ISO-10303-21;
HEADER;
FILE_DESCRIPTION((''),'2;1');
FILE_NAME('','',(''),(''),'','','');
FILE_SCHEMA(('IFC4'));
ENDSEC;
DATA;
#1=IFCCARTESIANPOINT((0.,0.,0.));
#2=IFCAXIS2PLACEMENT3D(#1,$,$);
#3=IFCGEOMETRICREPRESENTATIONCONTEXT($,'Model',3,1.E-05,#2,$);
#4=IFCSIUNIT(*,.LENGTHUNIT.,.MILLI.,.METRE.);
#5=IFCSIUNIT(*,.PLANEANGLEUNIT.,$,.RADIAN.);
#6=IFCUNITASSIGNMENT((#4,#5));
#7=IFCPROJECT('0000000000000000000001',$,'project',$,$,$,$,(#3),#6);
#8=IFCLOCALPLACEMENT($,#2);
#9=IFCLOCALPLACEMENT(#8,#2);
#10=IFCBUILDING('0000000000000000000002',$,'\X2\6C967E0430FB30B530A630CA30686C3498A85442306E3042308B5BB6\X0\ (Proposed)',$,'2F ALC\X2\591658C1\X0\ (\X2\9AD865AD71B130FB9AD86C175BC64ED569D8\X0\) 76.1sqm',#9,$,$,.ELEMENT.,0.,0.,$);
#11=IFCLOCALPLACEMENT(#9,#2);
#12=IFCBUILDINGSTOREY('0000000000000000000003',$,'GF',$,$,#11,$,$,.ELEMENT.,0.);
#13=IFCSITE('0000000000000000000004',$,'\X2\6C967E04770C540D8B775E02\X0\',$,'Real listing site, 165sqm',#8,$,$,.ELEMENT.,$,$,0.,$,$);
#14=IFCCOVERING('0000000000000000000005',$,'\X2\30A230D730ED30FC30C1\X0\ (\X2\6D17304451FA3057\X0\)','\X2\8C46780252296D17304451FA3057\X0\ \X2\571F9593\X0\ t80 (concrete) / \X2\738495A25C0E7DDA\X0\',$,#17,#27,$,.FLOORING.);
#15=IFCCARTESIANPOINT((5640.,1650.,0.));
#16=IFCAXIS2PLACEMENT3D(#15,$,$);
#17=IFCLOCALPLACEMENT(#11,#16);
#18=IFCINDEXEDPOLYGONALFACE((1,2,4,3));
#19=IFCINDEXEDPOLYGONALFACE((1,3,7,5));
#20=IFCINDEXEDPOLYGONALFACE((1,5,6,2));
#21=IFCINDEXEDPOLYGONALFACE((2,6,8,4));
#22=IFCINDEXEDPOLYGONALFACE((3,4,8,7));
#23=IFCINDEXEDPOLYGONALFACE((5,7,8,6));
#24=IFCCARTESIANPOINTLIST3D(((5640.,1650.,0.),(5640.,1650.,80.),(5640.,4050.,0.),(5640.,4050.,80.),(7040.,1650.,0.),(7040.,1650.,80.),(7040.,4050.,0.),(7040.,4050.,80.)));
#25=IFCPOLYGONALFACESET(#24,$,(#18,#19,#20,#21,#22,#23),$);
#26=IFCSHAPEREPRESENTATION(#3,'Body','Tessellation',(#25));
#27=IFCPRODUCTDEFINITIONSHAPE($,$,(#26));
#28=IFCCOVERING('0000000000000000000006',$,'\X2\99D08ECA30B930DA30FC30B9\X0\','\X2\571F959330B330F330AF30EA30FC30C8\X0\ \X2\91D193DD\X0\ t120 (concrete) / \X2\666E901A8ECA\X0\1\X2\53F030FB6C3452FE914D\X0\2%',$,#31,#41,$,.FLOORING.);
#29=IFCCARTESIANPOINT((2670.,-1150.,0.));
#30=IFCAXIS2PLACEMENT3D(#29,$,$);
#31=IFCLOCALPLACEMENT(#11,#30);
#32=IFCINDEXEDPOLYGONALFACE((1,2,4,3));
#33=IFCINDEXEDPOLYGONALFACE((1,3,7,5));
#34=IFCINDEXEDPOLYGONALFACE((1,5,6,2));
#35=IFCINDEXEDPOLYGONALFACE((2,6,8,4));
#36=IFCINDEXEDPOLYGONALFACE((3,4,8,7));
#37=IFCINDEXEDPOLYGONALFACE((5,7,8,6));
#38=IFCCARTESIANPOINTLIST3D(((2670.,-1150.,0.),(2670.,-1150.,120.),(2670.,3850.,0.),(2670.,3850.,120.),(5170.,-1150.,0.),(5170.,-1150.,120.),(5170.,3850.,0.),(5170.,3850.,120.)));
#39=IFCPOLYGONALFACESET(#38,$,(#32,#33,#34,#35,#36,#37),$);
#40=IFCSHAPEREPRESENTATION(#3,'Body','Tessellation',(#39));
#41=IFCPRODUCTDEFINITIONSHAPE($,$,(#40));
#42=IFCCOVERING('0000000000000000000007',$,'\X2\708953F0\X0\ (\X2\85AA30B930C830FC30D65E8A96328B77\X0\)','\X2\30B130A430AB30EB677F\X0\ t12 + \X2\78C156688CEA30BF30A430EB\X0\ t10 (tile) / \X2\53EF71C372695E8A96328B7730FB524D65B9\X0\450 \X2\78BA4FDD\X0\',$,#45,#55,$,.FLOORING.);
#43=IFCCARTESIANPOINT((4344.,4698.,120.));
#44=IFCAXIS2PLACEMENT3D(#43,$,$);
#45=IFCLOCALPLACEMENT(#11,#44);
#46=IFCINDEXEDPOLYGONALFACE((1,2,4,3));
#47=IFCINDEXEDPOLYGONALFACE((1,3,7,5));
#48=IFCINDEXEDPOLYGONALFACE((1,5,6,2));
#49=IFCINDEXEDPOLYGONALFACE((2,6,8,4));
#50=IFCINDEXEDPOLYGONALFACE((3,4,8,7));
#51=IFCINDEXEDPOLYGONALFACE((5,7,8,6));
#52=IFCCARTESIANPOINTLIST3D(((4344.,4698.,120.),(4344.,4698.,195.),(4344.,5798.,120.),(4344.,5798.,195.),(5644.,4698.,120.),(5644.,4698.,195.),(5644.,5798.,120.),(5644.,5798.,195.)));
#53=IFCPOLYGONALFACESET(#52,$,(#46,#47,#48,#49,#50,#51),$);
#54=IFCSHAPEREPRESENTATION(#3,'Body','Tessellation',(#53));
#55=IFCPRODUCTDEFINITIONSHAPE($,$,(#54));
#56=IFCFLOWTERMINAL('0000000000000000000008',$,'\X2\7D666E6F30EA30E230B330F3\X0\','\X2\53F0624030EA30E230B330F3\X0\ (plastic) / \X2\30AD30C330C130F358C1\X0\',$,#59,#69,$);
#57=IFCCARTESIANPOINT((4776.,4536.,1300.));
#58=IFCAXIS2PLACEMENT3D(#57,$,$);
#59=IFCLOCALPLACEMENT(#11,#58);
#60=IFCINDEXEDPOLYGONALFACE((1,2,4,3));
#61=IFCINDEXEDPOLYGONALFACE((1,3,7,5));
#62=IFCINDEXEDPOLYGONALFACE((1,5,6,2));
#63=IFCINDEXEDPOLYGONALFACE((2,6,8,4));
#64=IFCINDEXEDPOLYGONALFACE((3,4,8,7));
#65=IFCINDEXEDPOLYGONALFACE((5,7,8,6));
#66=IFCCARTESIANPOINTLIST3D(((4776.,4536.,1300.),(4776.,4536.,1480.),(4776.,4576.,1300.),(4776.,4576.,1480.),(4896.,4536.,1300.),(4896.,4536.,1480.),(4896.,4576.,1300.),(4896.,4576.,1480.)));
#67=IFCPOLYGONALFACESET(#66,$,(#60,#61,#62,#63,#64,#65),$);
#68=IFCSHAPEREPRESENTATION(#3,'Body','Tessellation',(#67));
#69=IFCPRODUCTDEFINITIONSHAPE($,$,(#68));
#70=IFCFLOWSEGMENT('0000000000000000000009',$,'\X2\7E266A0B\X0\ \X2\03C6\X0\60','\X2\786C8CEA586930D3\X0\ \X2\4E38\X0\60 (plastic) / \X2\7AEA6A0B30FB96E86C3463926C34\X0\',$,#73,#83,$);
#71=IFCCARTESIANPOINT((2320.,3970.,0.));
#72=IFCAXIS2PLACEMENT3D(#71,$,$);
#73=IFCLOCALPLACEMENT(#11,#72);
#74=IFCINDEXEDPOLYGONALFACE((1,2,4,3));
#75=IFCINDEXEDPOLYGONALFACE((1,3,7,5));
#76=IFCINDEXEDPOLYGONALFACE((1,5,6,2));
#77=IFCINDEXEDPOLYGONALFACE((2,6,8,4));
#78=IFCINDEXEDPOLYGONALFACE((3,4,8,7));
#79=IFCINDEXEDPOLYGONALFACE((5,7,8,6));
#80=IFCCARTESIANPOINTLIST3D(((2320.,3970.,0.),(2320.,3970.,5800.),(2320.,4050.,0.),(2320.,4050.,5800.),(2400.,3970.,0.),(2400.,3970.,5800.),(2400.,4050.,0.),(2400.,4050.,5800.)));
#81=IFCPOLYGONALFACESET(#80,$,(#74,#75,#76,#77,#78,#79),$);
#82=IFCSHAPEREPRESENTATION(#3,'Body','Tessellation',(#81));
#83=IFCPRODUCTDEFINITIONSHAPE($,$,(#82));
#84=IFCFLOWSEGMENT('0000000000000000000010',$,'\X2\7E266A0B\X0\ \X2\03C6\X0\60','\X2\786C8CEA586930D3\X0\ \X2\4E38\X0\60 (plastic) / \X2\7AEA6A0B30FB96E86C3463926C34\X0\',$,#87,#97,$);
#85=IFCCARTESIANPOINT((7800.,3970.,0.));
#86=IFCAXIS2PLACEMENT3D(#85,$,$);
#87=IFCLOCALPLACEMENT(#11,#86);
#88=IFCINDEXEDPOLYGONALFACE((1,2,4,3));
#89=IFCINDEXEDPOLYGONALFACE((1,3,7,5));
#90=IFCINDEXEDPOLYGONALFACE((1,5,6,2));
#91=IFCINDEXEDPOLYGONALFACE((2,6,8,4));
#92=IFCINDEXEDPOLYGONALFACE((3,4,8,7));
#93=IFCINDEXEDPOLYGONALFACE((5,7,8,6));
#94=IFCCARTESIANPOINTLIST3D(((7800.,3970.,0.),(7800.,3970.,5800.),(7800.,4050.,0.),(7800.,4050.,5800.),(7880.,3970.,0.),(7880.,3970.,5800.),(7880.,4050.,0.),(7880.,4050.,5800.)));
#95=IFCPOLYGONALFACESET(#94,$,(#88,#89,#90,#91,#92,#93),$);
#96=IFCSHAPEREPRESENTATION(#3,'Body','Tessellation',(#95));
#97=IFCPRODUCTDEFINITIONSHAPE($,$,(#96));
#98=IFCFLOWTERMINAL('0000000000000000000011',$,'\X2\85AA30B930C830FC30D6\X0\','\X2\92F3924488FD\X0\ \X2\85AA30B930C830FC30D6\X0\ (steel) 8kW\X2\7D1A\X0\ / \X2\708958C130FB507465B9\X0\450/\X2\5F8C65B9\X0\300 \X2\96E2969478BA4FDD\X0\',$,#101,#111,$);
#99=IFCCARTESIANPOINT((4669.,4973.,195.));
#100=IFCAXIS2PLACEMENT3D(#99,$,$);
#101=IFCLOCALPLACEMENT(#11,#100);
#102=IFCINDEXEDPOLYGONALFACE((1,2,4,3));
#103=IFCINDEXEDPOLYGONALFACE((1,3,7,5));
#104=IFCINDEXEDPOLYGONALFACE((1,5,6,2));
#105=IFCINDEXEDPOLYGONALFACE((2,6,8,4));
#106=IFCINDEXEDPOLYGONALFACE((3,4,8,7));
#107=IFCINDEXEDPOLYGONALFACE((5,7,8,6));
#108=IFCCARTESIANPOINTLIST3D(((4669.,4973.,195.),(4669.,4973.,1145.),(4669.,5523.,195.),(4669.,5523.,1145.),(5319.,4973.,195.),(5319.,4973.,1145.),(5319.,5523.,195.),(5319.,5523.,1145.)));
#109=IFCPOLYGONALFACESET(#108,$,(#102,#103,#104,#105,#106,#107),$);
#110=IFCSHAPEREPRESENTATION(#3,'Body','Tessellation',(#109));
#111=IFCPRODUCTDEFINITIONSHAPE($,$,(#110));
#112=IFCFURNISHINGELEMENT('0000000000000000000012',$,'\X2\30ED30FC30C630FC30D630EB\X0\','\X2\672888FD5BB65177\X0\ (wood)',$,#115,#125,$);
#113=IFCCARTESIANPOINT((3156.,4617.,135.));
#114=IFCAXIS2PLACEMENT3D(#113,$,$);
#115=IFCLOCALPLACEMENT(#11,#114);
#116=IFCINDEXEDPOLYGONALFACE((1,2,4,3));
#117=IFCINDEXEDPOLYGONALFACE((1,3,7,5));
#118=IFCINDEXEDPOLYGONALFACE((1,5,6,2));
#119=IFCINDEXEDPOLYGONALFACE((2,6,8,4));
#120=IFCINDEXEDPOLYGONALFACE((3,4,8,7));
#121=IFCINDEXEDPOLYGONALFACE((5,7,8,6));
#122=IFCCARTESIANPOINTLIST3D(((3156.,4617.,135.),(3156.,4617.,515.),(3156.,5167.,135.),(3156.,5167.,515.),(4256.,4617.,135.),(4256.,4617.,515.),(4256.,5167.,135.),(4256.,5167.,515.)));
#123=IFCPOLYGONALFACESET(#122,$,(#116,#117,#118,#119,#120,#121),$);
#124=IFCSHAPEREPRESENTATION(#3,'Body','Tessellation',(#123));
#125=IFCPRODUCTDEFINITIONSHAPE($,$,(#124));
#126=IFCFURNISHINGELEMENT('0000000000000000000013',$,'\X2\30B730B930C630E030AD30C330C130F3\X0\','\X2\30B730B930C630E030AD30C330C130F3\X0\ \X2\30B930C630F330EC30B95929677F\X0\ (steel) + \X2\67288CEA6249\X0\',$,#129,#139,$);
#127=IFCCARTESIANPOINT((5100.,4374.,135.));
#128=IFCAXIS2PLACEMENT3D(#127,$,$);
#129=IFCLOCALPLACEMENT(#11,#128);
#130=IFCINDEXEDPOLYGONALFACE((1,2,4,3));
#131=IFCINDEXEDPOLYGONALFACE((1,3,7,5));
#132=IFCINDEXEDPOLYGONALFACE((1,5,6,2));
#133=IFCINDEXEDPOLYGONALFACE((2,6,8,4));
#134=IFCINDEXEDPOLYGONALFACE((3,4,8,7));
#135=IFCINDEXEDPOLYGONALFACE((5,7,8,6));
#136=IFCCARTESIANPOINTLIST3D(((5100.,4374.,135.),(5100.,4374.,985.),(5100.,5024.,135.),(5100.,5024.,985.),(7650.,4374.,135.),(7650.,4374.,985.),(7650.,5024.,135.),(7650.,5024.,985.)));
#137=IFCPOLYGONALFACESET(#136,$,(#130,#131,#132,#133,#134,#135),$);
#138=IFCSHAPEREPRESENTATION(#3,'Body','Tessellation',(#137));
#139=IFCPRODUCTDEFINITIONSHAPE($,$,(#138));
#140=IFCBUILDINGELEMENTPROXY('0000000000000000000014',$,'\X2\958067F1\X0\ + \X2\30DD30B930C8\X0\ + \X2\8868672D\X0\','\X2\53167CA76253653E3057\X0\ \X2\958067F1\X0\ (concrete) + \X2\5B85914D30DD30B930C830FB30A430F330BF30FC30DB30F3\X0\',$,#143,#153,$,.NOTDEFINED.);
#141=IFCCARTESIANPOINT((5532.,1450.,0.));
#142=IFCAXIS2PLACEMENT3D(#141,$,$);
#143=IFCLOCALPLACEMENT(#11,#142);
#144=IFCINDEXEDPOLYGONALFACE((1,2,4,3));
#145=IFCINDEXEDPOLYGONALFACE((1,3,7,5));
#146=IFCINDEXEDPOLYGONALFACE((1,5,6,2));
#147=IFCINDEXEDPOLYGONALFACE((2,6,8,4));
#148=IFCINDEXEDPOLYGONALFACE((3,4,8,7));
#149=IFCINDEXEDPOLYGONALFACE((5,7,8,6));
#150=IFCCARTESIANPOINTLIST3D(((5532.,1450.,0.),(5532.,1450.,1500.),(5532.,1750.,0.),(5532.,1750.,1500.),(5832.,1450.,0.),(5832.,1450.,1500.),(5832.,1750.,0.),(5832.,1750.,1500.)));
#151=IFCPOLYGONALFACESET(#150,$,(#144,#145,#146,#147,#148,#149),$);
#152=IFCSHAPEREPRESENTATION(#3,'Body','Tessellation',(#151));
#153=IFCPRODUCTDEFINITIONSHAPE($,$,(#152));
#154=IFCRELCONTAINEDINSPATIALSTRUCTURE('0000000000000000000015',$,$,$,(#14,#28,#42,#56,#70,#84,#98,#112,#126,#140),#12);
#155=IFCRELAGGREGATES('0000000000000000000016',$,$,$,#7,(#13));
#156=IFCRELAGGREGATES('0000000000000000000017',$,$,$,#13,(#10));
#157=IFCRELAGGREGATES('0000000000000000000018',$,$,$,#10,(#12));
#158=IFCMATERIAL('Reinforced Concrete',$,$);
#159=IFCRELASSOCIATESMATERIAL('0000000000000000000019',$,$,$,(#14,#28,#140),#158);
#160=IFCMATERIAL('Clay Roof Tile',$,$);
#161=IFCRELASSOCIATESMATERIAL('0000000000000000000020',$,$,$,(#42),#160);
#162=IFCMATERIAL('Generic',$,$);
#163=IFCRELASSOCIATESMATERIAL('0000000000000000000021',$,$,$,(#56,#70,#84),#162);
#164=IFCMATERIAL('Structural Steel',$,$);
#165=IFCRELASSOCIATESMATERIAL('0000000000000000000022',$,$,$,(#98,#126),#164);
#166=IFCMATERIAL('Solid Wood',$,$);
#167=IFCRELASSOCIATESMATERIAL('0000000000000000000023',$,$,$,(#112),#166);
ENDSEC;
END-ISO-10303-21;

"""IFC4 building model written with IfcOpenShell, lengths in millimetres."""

from ifc_helpers import new_model, si_unit, frame, frame_2d, origin, place, context, project, spatial, rectangle, extrude, material, element, save


model = new_model("IFC4")

# Units and contexts
model_context = context("Model", 3, precision=1e-05, world=origin())
ifc_project = project(units=[si_unit("LENGTHUNIT", "METRE", prefix="MILLI"), si_unit("PLANEANGLEUNIT", "RADIAN")], contexts=[model_context])

# Site, building, storey
site_placement = place(None, origin())
site = spatial("IfcSite", under=ifc_project, at=site_placement, Name="沖縄県名護市", ObjectType="Real listing site, 165sqm", CompositionType="ELEMENT", RefElevation=0.0)
building_placement = place(site_placement, origin())
building = spatial("IfcBuilding", under=site, at=building_placement, Name="沖縄・サウナと水風呂のある家 (Proposed)", ObjectType="2F ALC外壁 (高断熱・高気密仕様) 76.1sqm", CompositionType="ELEMENT", ElevationOfRefHeight=0.0, ElevationOfTerrain=0.0)
storey_placement = place(building_placement, origin())
storey = spatial("IfcBuildingStorey", under=building, at=storey_placement, Name="GF", CompositionType="ELEMENT", Elevation=0.0)

# Shared definitions
ifc_material_1 = material(Name="Solid Wood")

# Shared definitions
ifc_material_2 = material(Name="Reinforced Concrete")

# Coverings
ifc_material_3 = material(Name="Generic")
covering_1_placement = place(storey_placement, frame((5640.0, 1650.0, 0.0)))
element("IfcCovering", 1, at=covering_1_placement, inside=storey, material=ifc_material_2, Name="アプローチ (洗い出し)", Description="豆砂利洗い出し 土間 t80 (concrete) / 玄関導線", PredefinedType="FLOORING", context=model_context, shape_type="SweptSolid", body=[
    extrude(rectangle(XDim=1400.0, YDim=2400.0, at=frame_2d((700.0, 1200.0))), frame((5640.0, 1650.0, 0.0)), (0.0, 0.0, 1.0), 80.0),
])
covering_2_placement = place(storey_placement, frame((2670.0, -1150.0, 0.0)))
element("IfcCovering", 2, at=covering_2_placement, inside=storey, material=ifc_material_2, Name="駐車スペース", Description="土間コンクリート 金鏝 t120 (concrete) / 普通車1台・水勾配2%", PredefinedType="FLOORING", context=model_context, shape_type="SweptSolid", body=[
    extrude(rectangle(XDim=2500.0, YDim=5000.0, at=frame_2d((1250.0, 2500.0))), frame((2670.0, -1150.0, 0.0)), (0.0, 0.0, 1.0), 120.0),
])
ifc_material_4 = material(Name="Clay Roof Tile")
covering_3_placement = place(storey_placement, frame((4344.0, 4698.0, 120.0)))
element("IfcCovering", 3, at=covering_3_placement, inside=storey, material=ifc_material_4, Name="炉台 (薪ストーブ床防護)", Description="ケイカル板 t12 + 磁器質タイル t10 (tile) / 可燃物床防護・前方450 確保", PredefinedType="FLOORING", context=model_context, shape_type="SweptSolid", body=[
    extrude(rectangle(XDim=1300.0, YDim=1100.0, at=frame_2d((650.0, 550.0))), frame((4344.0, 4698.0, 120.0)), (0.0, 0.0, 1.0), 75.0),
])

# Flow terminal
flow_terminal_1_placement = place(storey_placement, frame((4776.0, 4536.0, 1300.0)))
element("IfcFlowTerminal", 4, at=flow_terminal_1_placement, inside=storey, material=ifc_material_3, Name="給湯リモコン", Description="台所リモコン (plastic) / キッチン壁", context=model_context, shape_type="SweptSolid", body=[
    extrude(rectangle(XDim=120.0, YDim=40.0, at=frame_2d((60.0, 20.0))), frame((4776.0, 4536.0, 1300.0)), (0.0, 0.0, 1.0), 180.0),
])

# Flow segments
flow_segment_1_placement = place(storey_placement, frame((2320.0, 3970.0, 0.0)))
element("IfcFlowSegment", 5, at=flow_segment_1_placement, inside=storey, material=ifc_material_3, Name="縦樋 φ60", Description="硬質塩ビ 丸60 (plastic) / 竪樋・雨水排水", context=model_context, shape_type="SweptSolid", body=[
    extrude(rectangle(XDim=80.0, YDim=80.0, at=frame_2d((40.0, 40.0))), frame((2320.0, 3970.0, 0.0)), (0.0, 0.0, 1.0), 5800.0),
])
flow_segment_2_placement = place(storey_placement, frame((7800.0, 3970.0, 0.0)))
element("IfcFlowSegment", 6, at=flow_segment_2_placement, inside=storey, material=ifc_material_3, Name="縦樋 φ60", Description="硬質塩ビ 丸60 (plastic) / 竪樋・雨水排水", context=model_context, shape_type="SweptSolid", body=[
    extrude(rectangle(XDim=80.0, YDim=80.0, at=frame_2d((40.0, 40.0))), frame((7800.0, 3970.0, 0.0)), (0.0, 0.0, 1.0), 5800.0),
])

# Flow terminal
ifc_material_5 = material(Name="Structural Steel")
flow_terminal_2_placement = place(storey_placement, frame((4669.0, 4973.0, 195.0)))
element("IfcFlowTerminal", 7, at=flow_terminal_2_placement, inside=storey, material=ifc_material_5, Name="薪ストーブ", Description="鋳鉄製 薪ストーブ (steel) 8kW級 / 炉壁・側方450/後方300 離隔確保", context=model_context, shape_type="SweptSolid", body=[
    extrude(rectangle(XDim=650.0, YDim=550.0, at=frame_2d((325.0, 275.0))), frame((4669.0, 4973.0, 195.0)), (0.0, 0.0, 1.0), 950.0),
])

# Furnishing elements
furnishing_1_placement = place(storey_placement, frame((3156.0, 4617.0, 135.0)))
element("IfcFurnishingElement", 8, at=furnishing_1_placement, inside=storey, material=ifc_material_1, Name="ローテーブル", Description="木製家具 (wood)", context=model_context, shape_type="SweptSolid", body=[
    extrude(rectangle(XDim=1100.0, YDim=550.0, at=frame_2d((550.0, 275.0))), frame((3156.0, 4617.0, 135.0)), (0.0, 0.0, 1.0), 380.0),
])
furnishing_2_placement = place(storey_placement, frame((5100.0, 4374.0, 135.0)))
element("IfcFurnishingElement", 9, at=furnishing_2_placement, inside=storey, material=ifc_material_5, Name="システムキッチン", Description="システムキッチン ステンレス天板 (steel) + 木質扉", context=model_context, shape_type="SweptSolid", body=[
    extrude(rectangle(XDim=2550.0, YDim=650.0, at=frame_2d((1275.0, 325.0))), frame((5100.0, 4374.0, 135.0)), (0.0, 0.0, 1.0), 850.0),
])

# Building element proxy
proxy_placement = place(storey_placement, frame((5532.0, 1450.0, 0.0)))
element("IfcBuildingElementProxy", 10, at=proxy_placement, inside=storey, material=ifc_material_2, Name="門柱 + ポスト + 表札", Description="化粧打放し 門柱 (concrete) + 宅配ポスト・インターホン", PredefinedType="NOTDEFINED", context=model_context, shape_type="SweptSolid", body=[
    extrude(rectangle(XDim=300.0, YDim=300.0, at=frame_2d((150.0, 150.0))), frame((5532.0, 1450.0, 0.0)), (0.0, 0.0, 1.0), 1500.0),
])

save(model, "model.ifc")
